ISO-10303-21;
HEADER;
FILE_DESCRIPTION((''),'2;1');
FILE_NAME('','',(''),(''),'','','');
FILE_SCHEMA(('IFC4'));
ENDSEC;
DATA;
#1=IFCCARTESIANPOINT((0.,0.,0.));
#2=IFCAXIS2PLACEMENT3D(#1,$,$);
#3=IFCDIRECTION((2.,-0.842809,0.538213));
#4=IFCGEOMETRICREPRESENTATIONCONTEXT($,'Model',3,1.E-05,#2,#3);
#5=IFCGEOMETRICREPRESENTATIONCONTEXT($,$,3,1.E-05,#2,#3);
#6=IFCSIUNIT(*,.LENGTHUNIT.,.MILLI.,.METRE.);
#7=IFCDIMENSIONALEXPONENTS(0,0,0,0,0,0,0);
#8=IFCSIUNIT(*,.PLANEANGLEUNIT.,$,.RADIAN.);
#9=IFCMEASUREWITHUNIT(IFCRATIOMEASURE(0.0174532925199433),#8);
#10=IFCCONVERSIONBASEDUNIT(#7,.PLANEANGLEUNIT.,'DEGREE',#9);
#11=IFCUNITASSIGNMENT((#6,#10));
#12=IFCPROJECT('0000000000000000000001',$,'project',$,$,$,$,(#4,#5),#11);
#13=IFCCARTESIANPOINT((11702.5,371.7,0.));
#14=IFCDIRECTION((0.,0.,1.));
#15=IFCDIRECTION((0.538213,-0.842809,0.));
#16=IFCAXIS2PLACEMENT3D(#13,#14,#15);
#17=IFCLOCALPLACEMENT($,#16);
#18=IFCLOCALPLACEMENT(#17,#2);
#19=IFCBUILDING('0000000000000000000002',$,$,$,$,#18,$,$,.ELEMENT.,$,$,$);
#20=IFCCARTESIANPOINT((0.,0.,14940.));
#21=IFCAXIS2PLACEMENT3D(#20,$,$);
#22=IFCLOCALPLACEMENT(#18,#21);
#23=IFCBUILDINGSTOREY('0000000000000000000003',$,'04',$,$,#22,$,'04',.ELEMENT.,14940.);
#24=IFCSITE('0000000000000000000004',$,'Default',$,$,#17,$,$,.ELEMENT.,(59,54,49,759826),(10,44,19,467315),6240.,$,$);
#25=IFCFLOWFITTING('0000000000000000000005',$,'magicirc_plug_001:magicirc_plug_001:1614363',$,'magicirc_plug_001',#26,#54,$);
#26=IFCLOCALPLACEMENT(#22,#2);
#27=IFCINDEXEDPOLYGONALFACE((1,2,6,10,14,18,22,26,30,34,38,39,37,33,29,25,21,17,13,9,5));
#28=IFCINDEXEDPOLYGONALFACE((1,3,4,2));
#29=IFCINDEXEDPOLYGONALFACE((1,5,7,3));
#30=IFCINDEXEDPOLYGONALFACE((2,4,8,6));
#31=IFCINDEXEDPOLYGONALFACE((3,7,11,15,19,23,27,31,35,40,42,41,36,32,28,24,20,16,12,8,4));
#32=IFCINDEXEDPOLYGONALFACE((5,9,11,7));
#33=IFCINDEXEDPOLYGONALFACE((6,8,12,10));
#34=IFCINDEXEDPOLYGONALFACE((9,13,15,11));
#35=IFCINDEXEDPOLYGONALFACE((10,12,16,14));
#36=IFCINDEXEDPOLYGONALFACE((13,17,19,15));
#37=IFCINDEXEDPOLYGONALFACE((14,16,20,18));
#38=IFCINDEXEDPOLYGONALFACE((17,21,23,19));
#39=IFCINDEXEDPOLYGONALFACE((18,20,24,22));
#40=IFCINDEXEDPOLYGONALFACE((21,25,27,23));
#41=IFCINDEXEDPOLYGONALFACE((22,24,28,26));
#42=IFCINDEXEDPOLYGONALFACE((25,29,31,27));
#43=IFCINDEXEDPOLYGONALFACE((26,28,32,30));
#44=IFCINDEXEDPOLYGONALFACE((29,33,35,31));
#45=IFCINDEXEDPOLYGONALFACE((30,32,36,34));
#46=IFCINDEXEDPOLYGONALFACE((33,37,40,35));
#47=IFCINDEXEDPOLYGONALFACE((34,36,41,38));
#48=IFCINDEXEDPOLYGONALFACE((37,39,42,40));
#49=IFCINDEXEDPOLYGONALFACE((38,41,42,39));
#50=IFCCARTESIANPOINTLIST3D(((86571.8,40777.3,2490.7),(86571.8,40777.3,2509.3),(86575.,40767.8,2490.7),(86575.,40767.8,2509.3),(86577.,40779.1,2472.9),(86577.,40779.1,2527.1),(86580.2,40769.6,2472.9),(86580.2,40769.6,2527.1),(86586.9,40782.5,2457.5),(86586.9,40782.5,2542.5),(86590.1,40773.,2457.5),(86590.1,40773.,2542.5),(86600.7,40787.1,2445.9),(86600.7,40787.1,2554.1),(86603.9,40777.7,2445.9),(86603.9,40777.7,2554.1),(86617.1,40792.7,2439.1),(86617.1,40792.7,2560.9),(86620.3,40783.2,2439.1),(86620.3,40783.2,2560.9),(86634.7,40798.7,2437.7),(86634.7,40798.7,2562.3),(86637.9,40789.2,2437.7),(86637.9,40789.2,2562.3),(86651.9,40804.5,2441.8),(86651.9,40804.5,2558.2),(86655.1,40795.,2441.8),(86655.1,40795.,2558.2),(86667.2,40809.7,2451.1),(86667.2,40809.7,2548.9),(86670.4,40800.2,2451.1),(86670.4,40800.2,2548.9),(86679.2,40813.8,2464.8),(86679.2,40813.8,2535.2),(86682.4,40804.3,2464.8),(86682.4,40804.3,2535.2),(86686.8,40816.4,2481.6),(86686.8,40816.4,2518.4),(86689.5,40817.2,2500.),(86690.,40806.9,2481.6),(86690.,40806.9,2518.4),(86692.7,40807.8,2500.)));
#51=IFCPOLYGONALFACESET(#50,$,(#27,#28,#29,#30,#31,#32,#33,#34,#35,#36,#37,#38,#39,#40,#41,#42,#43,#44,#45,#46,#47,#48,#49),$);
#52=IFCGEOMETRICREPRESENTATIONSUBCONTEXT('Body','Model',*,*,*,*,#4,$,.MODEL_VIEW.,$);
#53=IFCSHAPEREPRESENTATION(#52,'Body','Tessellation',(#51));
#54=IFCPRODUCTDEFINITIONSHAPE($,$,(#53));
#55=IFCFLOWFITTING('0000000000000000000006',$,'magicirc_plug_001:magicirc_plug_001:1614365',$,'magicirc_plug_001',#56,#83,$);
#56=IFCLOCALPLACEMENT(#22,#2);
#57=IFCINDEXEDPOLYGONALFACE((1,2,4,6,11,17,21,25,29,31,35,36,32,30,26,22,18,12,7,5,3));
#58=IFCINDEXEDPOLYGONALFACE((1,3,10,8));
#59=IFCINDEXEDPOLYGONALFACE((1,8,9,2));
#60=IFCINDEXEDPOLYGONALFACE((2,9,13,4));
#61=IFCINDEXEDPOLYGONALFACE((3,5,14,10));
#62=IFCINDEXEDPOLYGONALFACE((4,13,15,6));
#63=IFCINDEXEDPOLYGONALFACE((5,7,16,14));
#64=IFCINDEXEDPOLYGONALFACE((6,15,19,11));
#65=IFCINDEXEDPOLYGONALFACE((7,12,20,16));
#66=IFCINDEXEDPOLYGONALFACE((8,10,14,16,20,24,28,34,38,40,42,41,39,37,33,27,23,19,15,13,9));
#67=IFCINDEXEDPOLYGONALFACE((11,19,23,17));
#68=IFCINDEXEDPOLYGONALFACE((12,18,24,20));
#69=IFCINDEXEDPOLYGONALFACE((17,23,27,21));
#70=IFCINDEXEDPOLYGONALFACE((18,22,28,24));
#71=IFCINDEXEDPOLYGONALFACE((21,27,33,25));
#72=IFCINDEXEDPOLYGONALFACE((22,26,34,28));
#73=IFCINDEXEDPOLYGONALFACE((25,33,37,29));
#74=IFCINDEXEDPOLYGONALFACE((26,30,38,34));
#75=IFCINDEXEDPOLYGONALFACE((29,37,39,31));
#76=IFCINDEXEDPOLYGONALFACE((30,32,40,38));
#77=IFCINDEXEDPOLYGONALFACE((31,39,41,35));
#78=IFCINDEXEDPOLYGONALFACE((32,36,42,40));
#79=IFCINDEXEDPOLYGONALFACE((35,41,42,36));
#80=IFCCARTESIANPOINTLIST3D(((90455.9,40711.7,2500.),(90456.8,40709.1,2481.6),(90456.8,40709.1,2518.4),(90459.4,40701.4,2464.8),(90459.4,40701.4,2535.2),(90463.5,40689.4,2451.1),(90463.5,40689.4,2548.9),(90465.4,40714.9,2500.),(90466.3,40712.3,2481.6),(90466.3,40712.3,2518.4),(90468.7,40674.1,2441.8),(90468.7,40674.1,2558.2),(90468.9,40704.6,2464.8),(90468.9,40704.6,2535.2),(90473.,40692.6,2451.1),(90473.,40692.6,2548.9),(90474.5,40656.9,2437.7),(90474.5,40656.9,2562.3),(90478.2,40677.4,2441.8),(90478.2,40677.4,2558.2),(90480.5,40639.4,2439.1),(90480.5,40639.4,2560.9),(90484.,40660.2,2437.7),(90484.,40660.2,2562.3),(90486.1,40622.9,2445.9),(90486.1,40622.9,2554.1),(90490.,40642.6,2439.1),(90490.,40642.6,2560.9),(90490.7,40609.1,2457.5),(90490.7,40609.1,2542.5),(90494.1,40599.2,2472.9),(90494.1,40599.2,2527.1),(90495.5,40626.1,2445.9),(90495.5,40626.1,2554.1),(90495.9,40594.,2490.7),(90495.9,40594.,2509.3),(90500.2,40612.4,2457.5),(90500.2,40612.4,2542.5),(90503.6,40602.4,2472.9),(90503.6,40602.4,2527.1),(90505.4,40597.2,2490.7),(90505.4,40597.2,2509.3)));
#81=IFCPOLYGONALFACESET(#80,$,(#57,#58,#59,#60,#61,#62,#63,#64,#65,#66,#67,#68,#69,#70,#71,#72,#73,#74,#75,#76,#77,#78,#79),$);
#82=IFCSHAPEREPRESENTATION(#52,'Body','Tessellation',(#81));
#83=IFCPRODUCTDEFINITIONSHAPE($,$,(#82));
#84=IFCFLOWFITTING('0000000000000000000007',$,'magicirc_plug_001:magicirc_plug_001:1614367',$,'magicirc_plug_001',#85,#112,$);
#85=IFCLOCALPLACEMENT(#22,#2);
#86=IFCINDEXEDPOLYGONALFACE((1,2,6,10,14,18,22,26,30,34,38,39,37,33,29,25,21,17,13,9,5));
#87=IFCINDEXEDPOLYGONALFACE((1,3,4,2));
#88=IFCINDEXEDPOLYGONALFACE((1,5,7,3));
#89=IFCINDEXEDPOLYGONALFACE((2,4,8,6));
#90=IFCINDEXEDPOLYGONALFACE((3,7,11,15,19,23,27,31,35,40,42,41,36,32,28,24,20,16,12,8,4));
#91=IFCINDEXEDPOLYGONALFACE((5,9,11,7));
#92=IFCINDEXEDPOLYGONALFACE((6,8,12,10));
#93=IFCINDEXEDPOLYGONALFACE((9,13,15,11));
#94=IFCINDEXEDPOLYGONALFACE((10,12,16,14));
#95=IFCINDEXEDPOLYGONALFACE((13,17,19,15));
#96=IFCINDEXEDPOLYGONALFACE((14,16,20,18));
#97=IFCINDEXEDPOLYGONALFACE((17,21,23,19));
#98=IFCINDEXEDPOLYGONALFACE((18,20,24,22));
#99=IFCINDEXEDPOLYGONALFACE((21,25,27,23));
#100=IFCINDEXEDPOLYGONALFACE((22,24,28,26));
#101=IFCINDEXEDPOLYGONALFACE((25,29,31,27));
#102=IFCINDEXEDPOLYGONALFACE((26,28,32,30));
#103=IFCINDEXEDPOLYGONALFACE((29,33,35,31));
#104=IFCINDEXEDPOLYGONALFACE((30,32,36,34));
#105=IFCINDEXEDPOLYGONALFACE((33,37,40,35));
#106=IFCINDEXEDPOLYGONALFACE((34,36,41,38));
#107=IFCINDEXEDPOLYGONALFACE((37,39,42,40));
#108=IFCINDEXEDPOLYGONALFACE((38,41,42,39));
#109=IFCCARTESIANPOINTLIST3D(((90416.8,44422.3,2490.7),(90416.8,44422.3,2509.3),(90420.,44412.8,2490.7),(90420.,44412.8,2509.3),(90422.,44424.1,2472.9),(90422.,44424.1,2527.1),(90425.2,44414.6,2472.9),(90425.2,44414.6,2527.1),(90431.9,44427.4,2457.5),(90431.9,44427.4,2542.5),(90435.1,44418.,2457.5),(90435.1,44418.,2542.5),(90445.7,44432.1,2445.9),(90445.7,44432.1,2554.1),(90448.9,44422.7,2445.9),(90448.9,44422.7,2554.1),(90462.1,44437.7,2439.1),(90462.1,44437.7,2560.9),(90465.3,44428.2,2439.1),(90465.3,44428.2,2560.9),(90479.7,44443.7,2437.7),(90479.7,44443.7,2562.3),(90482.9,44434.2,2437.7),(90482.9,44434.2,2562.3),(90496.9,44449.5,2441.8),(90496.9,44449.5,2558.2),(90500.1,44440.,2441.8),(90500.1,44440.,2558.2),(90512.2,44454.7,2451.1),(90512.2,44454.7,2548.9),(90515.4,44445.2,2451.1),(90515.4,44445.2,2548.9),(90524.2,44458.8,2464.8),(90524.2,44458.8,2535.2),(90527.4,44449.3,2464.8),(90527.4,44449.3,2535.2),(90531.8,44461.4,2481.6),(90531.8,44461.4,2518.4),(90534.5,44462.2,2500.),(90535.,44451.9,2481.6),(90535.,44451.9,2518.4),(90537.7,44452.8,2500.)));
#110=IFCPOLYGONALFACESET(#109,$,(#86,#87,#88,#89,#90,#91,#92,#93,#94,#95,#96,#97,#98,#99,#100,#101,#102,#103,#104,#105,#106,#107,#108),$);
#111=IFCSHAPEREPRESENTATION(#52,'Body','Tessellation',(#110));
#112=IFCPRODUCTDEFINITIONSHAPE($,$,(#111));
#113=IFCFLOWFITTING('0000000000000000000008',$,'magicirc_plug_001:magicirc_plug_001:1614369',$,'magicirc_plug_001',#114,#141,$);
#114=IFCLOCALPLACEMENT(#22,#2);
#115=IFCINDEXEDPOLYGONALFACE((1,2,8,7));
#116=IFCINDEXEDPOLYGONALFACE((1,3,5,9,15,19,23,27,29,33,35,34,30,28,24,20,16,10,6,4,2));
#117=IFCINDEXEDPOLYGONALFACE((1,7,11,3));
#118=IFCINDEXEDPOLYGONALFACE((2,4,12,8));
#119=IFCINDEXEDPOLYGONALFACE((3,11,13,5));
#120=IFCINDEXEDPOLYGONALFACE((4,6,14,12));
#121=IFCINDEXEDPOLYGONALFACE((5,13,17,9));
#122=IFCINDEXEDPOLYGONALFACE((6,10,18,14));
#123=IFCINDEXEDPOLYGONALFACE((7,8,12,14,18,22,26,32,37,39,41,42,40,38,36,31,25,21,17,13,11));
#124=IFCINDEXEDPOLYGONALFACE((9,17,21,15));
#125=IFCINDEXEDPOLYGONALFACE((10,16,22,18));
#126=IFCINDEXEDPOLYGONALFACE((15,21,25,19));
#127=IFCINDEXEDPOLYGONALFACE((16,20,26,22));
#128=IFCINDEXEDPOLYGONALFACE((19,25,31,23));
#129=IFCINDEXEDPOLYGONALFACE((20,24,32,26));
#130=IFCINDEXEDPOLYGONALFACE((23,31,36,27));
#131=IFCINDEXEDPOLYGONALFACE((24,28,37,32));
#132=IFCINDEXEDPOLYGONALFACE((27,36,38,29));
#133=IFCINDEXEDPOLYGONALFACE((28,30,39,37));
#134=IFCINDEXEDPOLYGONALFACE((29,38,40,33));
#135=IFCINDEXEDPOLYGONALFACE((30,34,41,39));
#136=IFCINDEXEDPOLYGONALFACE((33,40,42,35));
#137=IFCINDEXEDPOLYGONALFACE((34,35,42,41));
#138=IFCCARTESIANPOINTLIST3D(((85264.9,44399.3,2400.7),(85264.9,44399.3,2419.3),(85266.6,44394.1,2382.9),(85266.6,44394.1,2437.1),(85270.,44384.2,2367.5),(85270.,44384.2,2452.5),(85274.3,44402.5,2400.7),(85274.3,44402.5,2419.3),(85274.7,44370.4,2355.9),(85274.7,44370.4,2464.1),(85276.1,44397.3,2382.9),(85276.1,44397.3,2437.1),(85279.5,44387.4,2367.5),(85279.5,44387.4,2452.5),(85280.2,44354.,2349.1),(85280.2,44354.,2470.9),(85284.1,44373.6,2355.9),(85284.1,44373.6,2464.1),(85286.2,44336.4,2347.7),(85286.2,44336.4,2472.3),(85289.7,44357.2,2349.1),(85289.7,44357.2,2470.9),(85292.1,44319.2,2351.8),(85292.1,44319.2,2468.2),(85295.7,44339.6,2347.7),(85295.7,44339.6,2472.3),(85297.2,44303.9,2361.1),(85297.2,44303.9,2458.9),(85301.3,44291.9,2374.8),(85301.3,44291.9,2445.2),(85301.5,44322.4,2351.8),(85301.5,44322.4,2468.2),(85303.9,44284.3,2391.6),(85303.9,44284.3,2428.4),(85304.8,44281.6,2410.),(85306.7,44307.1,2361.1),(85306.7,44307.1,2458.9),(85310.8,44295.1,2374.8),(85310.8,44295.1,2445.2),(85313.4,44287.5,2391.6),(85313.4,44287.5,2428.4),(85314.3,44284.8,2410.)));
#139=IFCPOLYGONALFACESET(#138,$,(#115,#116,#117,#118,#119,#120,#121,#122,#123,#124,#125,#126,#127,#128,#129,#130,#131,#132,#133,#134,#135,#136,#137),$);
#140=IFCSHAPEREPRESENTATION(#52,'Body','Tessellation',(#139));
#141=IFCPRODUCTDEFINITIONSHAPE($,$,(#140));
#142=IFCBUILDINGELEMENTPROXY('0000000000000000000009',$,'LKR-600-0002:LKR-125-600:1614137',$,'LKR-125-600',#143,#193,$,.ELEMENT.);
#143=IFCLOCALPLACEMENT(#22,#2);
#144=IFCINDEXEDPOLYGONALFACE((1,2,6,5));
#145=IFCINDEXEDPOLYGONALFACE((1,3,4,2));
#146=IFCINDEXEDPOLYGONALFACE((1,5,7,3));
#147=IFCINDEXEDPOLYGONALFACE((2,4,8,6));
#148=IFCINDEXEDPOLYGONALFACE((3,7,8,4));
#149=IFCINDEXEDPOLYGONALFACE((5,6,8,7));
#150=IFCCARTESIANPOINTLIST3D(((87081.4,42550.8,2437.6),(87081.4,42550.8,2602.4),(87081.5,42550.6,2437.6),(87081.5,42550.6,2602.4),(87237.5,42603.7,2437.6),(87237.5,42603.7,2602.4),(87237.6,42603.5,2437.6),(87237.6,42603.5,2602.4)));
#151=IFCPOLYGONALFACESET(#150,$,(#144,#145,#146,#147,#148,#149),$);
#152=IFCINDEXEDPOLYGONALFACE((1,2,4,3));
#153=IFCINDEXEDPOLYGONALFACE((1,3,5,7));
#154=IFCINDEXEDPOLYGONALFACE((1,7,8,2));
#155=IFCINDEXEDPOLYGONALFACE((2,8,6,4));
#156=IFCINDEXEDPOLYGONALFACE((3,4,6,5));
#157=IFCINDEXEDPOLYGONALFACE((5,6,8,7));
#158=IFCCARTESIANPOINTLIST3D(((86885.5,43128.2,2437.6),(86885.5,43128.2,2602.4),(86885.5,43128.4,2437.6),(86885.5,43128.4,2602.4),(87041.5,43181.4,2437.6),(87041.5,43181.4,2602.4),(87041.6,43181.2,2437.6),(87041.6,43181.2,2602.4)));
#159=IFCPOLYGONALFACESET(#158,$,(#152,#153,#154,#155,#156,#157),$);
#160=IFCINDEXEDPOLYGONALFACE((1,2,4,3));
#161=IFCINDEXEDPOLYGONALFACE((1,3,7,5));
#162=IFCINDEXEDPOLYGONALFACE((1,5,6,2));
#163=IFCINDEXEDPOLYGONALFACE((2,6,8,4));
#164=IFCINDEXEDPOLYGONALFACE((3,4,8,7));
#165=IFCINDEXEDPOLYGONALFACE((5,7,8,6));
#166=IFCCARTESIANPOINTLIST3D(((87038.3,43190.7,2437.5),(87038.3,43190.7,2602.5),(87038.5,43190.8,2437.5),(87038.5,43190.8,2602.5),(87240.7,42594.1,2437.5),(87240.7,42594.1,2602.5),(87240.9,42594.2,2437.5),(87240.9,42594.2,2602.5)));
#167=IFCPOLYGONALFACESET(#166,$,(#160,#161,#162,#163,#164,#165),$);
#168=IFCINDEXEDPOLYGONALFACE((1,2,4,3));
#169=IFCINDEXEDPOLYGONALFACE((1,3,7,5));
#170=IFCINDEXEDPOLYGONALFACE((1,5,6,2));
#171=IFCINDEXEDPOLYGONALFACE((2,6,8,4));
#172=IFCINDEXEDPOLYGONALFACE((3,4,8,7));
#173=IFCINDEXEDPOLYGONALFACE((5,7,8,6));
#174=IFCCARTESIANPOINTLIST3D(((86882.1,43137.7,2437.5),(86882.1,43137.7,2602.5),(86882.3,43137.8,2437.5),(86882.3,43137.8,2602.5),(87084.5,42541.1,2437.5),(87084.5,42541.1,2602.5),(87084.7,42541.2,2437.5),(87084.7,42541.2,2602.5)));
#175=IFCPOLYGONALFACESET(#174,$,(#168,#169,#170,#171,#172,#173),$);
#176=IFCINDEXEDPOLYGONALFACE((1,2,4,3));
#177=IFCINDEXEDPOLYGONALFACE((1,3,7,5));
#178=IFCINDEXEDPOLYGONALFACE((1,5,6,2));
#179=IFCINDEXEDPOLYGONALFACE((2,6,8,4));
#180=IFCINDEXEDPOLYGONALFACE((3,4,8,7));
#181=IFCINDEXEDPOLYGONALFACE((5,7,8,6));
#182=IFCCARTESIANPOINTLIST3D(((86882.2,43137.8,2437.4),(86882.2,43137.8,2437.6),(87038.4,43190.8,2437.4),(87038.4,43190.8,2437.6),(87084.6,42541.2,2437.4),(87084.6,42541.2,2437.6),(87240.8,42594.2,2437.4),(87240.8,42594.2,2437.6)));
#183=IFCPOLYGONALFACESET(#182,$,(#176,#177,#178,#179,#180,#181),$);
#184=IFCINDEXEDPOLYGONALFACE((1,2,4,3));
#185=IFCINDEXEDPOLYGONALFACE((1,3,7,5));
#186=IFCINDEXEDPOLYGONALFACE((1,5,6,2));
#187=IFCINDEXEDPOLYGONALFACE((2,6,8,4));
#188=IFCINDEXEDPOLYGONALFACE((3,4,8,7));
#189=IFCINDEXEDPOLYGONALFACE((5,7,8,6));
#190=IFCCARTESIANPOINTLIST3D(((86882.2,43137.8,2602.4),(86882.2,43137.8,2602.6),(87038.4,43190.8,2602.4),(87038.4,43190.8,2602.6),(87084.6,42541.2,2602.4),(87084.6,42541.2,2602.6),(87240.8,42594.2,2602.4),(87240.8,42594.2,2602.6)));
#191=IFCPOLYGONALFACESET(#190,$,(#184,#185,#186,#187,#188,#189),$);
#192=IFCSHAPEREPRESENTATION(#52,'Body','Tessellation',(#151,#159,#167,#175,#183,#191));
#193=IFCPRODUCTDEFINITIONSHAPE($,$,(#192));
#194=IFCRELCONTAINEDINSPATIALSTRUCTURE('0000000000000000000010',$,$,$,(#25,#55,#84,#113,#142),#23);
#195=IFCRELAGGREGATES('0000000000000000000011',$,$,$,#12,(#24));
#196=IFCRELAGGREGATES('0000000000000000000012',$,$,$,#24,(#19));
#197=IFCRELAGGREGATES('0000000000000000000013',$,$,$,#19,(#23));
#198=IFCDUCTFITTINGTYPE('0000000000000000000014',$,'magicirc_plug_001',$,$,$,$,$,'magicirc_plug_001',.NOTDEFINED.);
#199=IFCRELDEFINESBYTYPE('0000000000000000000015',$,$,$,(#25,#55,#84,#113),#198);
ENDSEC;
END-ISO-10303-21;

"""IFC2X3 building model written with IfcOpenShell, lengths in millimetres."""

from ifc_helpers import new_model, entity, si_unit, converted_unit, direction, frame, frame_2d, origin, place, context, subcontext, project, spatial, rectangle, circle, extrude, source, transform, mapped, type_object, type_shapes, element, save


model = new_model("IFC2X3")

# Units and contexts
model_context = context("Model", 3, precision=1e-05, world=origin(), true_north=direction((2.0, -0.842809, 0.538213)))
context_of_model = context(None, 3, precision=1e-05, world=origin(), true_north=direction((2.0, -0.842809, 0.538213)))
body_context = subcontext(model_context, "Body", "Model", "MODEL_VIEW")
ifc_project = project(units=[si_unit("LENGTHUNIT", "METRE", prefix="MILLI"), converted_unit("PLANEANGLEUNIT", "DEGREE", entity("IfcRatioMeasure", 0.0174532925199433), si_unit("PLANEANGLEUNIT", "RADIAN"), dimensions=[0, 0, 0, 0, 0, 0, 0])], contexts=[model_context, context_of_model])

# Site, building, storey
site_placement = place(None, frame((11702.5, 371.7, 0.0), z_axis=(0.0, 0.0, 1.0), x_axis=(0.538213, -0.842809, 0.0)))
site = spatial("IfcSite", under=ifc_project, at=site_placement, Name="Default", CompositionType="ELEMENT", RefLatitude=(59, 54, 49, 759826), RefLongitude=(10, 44, 19, 467315), RefElevation=6240.0)
building_placement = place(site_placement, origin())
building = spatial("IfcBuilding", under=site, at=building_placement, CompositionType="ELEMENT")
storey_placement = place(building_placement, frame((0.0, 0.0, 14940.0)))
storey = spatial("IfcBuildingStorey", under=building, at=storey_placement, Name="04", LongName="04", CompositionType="ELEMENT", Elevation=14940.0)

# Flow fittings
duct_fitting_type_1 = type_object("IfcDuctFittingType", Name="magicirc_plug_001", ElementType="magicirc_plug_001", PredefinedType="NOTDEFINED")
shared_shape_1 = source(origin(), body_context, "Body", "SweptSolid", [
    extrude(circle(Radius=62.5, at=frame_2d((0.0, 0.0), x_axis=(1.0, 0.0))), frame((0.0, 0.0, 0.0), z_axis=(1.0, 0.0, 0.0), x_axis=(0.0, 1.0, 0.0)), (0.0, 0.0, 1.0), 10.0),
])
type_shapes(duct_fitting_type_1, [shared_shape_1])
for number, where, z_axis, x_axis, name in (
    (1, (86630.3, 40797.2, 2500.0), (0.0, 0.0, 1.0), (0.321274, -0.946986, 0.0), "magicirc_plug_001:magicirc_plug_001:1614363"),
    (2, (90476.0, 40652.5, 2500.0), (0.0, 0.0, 1.0), (0.946986, 0.321274, 0.0), "magicirc_plug_001:magicirc_plug_001:1614365"),
    (3, (90475.3, 44442.2, 2500.0), (0.0, 0.0, 1.0), (0.321274, -0.946986, 0.0), "magicirc_plug_001:magicirc_plug_001:1614367"),
    (4, (85294.2, 44344.0, 2410.0), (0.0, 0.0, 1.0), (-0.946986, -0.321274, 0.0), "magicirc_plug_001:magicirc_plug_001:1614369"),
):
    element("IfcFlowFitting", number, at=place(storey_placement, frame(where, z_axis=z_axis, x_axis=x_axis)), inside=storey, type_object=duct_fitting_type_1, Name=name, ObjectType="magicirc_plug_001", context=body_context, shape_type="MappedRepresentation", body=[
        mapped(shared_shape_1, transform((0.0, 0.0, 0.0), scale=1.0)),
    ])

# Building element proxy
shared_shape_2 = source(origin(), body_context, "Body", "SweptSolid", [
    extrude(rectangle(XDim=0.2, YDim=164.8, at=frame_2d((0.0, 0.0), x_axis=(1.0, 0.0))), frame((305.0, 0.0, -82.4)), (0.0, 0.0, 1.0), 164.8),
    extrude(rectangle(XDim=0.2, YDim=164.8, at=frame_2d((0.0, 0.0), x_axis=(1.0, 0.0))), frame((-305.0, 0.0, -82.4)), (0.0, 0.0, 1.0), 164.8),
    extrude(rectangle(XDim=0.2, YDim=630.0, at=frame_2d((0.0, 0.0), x_axis=(1.0, 0.0))), frame((0.0, 82.5, -82.5), z_axis=(0.0, 0.0, 1.0), x_axis=(0.0, 1.0, 0.0)), (0.0, 0.0, 1.0), 165.0),
    extrude(rectangle(XDim=0.2, YDim=630.0, at=frame_2d((0.0, 0.0), x_axis=(1.0, 0.0))), frame((0.0, -82.5, -82.5), z_axis=(0.0, 0.0, 1.0), x_axis=(0.0, 1.0, 0.0)), (0.0, 0.0, 1.0), 165.0),
    extrude(rectangle(XDim=165.0, YDim=630.0, at=frame_2d((0.0, 0.0), x_axis=(1.0, 0.0))), frame((0.0, 0.0, -82.6), z_axis=(0.0, 0.0, 1.0), x_axis=(0.0, -1.0, 0.0)), (0.0, 0.0, 1.0), 0.2),
    extrude(rectangle(XDim=165.0, YDim=630.0, at=frame_2d((0.0, 0.0), x_axis=(1.0, 0.0))), frame((0.0, 0.0, 82.4), z_axis=(0.0, 0.0, 1.0), x_axis=(0.0, -1.0, 0.0)), (0.0, 0.0, 1.0), 0.2),
])
for number, where, z_axis, x_axis, name in (
    (5, (87061.5, 42866.0, 2520.0), (0.0, 0.0, 1.0), (0.321274, -0.946986, 0.0), "LKR-600-0002:LKR-125-600:1614137"),
):
    element("IfcBuildingElementProxy", number, at=place(storey_placement, frame(where, z_axis=z_axis, x_axis=x_axis)), inside=storey, Name=name, ObjectType="LKR-125-600", CompositionType="ELEMENT", context=body_context, shape_type="MappedRepresentation", body=[
        mapped(shared_shape_2, transform((0.0, 0.0, 0.0), scale=1.0)),
    ])

save(model, "model.ifc")
